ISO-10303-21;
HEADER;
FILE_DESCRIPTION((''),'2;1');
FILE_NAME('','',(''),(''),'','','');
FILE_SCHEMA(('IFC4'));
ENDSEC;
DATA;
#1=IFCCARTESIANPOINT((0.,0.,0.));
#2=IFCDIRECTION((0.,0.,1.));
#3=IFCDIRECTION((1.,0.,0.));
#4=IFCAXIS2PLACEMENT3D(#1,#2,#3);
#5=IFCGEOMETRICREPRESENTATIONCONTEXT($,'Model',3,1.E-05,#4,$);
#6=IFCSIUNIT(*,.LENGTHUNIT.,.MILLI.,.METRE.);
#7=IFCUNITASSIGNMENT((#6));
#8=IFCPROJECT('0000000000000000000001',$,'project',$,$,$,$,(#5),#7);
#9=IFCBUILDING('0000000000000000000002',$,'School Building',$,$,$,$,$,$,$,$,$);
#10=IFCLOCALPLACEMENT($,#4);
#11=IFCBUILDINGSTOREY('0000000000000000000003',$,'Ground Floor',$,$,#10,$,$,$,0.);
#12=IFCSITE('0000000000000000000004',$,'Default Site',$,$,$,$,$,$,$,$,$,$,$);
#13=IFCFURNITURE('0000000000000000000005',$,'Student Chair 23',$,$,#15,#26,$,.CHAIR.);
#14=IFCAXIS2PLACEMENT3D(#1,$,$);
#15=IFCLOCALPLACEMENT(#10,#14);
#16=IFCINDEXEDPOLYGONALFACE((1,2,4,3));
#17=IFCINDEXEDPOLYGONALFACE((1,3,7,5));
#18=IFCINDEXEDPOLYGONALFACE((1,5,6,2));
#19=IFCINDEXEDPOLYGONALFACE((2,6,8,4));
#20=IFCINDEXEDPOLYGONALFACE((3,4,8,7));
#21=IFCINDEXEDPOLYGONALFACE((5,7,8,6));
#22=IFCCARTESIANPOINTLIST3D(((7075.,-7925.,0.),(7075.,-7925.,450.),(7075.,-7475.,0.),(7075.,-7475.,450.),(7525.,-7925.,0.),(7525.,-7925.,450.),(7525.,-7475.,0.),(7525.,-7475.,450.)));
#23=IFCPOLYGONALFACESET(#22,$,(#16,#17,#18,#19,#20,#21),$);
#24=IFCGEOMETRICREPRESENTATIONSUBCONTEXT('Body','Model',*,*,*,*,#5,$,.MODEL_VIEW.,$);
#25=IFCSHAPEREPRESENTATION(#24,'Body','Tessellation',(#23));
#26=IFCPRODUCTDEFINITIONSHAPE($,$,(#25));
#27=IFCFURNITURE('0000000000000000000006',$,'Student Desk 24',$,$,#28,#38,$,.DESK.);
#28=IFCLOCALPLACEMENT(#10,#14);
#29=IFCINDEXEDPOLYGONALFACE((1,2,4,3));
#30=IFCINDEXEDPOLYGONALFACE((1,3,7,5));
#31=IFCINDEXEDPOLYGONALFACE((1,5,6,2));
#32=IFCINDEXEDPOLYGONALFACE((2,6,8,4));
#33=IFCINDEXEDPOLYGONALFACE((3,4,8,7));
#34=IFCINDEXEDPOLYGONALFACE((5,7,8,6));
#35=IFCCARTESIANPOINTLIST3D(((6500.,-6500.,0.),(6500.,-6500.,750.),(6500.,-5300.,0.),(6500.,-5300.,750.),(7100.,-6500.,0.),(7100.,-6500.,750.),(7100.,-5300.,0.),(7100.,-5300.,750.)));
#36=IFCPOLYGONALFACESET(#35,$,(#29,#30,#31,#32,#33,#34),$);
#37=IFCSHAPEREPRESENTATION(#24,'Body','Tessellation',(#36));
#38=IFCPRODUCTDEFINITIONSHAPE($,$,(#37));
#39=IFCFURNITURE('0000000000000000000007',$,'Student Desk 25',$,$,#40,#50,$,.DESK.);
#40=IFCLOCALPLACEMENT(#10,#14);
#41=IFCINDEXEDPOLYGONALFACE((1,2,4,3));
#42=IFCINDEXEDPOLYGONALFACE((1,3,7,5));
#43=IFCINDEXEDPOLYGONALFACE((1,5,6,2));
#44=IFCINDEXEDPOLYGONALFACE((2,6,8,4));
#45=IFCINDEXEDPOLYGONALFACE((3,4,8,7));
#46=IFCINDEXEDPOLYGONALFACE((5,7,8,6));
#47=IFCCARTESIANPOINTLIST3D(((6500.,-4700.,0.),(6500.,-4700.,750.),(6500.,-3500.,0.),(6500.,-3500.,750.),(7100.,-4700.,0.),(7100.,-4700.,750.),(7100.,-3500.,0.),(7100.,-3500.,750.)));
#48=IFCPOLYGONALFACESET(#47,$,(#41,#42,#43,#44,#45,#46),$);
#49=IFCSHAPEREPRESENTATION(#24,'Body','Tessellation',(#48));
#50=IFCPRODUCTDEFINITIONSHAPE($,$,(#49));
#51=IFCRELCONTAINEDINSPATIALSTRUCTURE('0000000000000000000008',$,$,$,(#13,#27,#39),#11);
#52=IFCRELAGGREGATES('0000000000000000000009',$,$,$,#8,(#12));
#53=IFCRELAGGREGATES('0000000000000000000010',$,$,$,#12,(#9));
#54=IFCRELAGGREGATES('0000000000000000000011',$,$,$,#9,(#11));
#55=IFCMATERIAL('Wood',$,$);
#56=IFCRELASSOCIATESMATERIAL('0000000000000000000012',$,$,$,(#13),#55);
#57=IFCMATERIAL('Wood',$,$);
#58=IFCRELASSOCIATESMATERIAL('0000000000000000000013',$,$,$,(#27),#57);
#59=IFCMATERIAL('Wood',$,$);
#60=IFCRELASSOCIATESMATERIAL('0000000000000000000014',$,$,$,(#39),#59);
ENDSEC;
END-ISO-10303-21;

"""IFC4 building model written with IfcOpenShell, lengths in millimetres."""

from ifc_helpers import new_model, si_unit, frame, origin_with_axes, origin_2d, place, context, subcontext, project, spatial, rectangle, extrude, material, element, save


model = new_model("IFC4")

# Units and contexts
model_context = context("Model", 3, precision=1e-05, world=origin_with_axes())
body_context = subcontext(model_context, "Body", "Model", "MODEL_VIEW")
ifc_project = project(units=[si_unit("LENGTHUNIT", "METRE", prefix="MILLI")], contexts=[model_context])

# Site, building, storey
site = spatial("IfcSite", under=ifc_project, Name="Default Site")
building = spatial("IfcBuilding", under=site, Name="School Building")
storey_placement = place(None, origin_with_axes())
storey = spatial("IfcBuildingStorey", under=building, at=storey_placement, Name="Ground Floor", Elevation=0.0)

# Furniture
ifc_material_1 = material(Name="Wood")
furniture_1_placement = place(storey_placement, frame((7300.0, -7700.0, 0.0), z_axis=(0.0, 0.0, 1.0), x_axis=(1.0, 0.0, 0.0)))
element("IfcFurniture", 1, at=furniture_1_placement, inside=storey, material=ifc_material_1, Name="Student Chair 23", PredefinedType="CHAIR", context=body_context, shape_type="SweptSolid", body=[
    extrude(rectangle(XDim=450.0, YDim=450.0, at=origin_2d()), origin_with_axes(), (0.0, 0.0, 1.0), 450.0),
])
ifc_material_2 = material(Name="Wood")
furniture_2_placement = place(storey_placement, frame((6800.0, -5900.0, 0.0), z_axis=(0.0, 0.0, 1.0), x_axis=(0.0, 1.0, 0.0)))
element("IfcFurniture", 2, at=furniture_2_placement, inside=storey, material=ifc_material_2, Name="Student Desk 24", PredefinedType="DESK", context=body_context, shape_type="SweptSolid", body=[
    extrude(rectangle(XDim=1200.0, YDim=600.0, at=origin_2d()), origin_with_axes(), (0.0, 0.0, 1.0), 750.0),
])
ifc_material_3 = material(Name="Wood")
furniture_3_placement = place(storey_placement, frame((6800.0, -4100.0, 0.0), z_axis=(0.0, 0.0, 1.0), x_axis=(0.0, 1.0, 0.0)))
element("IfcFurniture", 3, at=furniture_3_placement, inside=storey, material=ifc_material_3, Name="Student Desk 25", PredefinedType="DESK", context=body_context, shape_type="SweptSolid", body=[
    extrude(rectangle(XDim=1200.0, YDim=600.0, at=origin_2d()), origin_with_axes(), (0.0, 0.0, 1.0), 750.0),
])

save(model, "model.ifc")
